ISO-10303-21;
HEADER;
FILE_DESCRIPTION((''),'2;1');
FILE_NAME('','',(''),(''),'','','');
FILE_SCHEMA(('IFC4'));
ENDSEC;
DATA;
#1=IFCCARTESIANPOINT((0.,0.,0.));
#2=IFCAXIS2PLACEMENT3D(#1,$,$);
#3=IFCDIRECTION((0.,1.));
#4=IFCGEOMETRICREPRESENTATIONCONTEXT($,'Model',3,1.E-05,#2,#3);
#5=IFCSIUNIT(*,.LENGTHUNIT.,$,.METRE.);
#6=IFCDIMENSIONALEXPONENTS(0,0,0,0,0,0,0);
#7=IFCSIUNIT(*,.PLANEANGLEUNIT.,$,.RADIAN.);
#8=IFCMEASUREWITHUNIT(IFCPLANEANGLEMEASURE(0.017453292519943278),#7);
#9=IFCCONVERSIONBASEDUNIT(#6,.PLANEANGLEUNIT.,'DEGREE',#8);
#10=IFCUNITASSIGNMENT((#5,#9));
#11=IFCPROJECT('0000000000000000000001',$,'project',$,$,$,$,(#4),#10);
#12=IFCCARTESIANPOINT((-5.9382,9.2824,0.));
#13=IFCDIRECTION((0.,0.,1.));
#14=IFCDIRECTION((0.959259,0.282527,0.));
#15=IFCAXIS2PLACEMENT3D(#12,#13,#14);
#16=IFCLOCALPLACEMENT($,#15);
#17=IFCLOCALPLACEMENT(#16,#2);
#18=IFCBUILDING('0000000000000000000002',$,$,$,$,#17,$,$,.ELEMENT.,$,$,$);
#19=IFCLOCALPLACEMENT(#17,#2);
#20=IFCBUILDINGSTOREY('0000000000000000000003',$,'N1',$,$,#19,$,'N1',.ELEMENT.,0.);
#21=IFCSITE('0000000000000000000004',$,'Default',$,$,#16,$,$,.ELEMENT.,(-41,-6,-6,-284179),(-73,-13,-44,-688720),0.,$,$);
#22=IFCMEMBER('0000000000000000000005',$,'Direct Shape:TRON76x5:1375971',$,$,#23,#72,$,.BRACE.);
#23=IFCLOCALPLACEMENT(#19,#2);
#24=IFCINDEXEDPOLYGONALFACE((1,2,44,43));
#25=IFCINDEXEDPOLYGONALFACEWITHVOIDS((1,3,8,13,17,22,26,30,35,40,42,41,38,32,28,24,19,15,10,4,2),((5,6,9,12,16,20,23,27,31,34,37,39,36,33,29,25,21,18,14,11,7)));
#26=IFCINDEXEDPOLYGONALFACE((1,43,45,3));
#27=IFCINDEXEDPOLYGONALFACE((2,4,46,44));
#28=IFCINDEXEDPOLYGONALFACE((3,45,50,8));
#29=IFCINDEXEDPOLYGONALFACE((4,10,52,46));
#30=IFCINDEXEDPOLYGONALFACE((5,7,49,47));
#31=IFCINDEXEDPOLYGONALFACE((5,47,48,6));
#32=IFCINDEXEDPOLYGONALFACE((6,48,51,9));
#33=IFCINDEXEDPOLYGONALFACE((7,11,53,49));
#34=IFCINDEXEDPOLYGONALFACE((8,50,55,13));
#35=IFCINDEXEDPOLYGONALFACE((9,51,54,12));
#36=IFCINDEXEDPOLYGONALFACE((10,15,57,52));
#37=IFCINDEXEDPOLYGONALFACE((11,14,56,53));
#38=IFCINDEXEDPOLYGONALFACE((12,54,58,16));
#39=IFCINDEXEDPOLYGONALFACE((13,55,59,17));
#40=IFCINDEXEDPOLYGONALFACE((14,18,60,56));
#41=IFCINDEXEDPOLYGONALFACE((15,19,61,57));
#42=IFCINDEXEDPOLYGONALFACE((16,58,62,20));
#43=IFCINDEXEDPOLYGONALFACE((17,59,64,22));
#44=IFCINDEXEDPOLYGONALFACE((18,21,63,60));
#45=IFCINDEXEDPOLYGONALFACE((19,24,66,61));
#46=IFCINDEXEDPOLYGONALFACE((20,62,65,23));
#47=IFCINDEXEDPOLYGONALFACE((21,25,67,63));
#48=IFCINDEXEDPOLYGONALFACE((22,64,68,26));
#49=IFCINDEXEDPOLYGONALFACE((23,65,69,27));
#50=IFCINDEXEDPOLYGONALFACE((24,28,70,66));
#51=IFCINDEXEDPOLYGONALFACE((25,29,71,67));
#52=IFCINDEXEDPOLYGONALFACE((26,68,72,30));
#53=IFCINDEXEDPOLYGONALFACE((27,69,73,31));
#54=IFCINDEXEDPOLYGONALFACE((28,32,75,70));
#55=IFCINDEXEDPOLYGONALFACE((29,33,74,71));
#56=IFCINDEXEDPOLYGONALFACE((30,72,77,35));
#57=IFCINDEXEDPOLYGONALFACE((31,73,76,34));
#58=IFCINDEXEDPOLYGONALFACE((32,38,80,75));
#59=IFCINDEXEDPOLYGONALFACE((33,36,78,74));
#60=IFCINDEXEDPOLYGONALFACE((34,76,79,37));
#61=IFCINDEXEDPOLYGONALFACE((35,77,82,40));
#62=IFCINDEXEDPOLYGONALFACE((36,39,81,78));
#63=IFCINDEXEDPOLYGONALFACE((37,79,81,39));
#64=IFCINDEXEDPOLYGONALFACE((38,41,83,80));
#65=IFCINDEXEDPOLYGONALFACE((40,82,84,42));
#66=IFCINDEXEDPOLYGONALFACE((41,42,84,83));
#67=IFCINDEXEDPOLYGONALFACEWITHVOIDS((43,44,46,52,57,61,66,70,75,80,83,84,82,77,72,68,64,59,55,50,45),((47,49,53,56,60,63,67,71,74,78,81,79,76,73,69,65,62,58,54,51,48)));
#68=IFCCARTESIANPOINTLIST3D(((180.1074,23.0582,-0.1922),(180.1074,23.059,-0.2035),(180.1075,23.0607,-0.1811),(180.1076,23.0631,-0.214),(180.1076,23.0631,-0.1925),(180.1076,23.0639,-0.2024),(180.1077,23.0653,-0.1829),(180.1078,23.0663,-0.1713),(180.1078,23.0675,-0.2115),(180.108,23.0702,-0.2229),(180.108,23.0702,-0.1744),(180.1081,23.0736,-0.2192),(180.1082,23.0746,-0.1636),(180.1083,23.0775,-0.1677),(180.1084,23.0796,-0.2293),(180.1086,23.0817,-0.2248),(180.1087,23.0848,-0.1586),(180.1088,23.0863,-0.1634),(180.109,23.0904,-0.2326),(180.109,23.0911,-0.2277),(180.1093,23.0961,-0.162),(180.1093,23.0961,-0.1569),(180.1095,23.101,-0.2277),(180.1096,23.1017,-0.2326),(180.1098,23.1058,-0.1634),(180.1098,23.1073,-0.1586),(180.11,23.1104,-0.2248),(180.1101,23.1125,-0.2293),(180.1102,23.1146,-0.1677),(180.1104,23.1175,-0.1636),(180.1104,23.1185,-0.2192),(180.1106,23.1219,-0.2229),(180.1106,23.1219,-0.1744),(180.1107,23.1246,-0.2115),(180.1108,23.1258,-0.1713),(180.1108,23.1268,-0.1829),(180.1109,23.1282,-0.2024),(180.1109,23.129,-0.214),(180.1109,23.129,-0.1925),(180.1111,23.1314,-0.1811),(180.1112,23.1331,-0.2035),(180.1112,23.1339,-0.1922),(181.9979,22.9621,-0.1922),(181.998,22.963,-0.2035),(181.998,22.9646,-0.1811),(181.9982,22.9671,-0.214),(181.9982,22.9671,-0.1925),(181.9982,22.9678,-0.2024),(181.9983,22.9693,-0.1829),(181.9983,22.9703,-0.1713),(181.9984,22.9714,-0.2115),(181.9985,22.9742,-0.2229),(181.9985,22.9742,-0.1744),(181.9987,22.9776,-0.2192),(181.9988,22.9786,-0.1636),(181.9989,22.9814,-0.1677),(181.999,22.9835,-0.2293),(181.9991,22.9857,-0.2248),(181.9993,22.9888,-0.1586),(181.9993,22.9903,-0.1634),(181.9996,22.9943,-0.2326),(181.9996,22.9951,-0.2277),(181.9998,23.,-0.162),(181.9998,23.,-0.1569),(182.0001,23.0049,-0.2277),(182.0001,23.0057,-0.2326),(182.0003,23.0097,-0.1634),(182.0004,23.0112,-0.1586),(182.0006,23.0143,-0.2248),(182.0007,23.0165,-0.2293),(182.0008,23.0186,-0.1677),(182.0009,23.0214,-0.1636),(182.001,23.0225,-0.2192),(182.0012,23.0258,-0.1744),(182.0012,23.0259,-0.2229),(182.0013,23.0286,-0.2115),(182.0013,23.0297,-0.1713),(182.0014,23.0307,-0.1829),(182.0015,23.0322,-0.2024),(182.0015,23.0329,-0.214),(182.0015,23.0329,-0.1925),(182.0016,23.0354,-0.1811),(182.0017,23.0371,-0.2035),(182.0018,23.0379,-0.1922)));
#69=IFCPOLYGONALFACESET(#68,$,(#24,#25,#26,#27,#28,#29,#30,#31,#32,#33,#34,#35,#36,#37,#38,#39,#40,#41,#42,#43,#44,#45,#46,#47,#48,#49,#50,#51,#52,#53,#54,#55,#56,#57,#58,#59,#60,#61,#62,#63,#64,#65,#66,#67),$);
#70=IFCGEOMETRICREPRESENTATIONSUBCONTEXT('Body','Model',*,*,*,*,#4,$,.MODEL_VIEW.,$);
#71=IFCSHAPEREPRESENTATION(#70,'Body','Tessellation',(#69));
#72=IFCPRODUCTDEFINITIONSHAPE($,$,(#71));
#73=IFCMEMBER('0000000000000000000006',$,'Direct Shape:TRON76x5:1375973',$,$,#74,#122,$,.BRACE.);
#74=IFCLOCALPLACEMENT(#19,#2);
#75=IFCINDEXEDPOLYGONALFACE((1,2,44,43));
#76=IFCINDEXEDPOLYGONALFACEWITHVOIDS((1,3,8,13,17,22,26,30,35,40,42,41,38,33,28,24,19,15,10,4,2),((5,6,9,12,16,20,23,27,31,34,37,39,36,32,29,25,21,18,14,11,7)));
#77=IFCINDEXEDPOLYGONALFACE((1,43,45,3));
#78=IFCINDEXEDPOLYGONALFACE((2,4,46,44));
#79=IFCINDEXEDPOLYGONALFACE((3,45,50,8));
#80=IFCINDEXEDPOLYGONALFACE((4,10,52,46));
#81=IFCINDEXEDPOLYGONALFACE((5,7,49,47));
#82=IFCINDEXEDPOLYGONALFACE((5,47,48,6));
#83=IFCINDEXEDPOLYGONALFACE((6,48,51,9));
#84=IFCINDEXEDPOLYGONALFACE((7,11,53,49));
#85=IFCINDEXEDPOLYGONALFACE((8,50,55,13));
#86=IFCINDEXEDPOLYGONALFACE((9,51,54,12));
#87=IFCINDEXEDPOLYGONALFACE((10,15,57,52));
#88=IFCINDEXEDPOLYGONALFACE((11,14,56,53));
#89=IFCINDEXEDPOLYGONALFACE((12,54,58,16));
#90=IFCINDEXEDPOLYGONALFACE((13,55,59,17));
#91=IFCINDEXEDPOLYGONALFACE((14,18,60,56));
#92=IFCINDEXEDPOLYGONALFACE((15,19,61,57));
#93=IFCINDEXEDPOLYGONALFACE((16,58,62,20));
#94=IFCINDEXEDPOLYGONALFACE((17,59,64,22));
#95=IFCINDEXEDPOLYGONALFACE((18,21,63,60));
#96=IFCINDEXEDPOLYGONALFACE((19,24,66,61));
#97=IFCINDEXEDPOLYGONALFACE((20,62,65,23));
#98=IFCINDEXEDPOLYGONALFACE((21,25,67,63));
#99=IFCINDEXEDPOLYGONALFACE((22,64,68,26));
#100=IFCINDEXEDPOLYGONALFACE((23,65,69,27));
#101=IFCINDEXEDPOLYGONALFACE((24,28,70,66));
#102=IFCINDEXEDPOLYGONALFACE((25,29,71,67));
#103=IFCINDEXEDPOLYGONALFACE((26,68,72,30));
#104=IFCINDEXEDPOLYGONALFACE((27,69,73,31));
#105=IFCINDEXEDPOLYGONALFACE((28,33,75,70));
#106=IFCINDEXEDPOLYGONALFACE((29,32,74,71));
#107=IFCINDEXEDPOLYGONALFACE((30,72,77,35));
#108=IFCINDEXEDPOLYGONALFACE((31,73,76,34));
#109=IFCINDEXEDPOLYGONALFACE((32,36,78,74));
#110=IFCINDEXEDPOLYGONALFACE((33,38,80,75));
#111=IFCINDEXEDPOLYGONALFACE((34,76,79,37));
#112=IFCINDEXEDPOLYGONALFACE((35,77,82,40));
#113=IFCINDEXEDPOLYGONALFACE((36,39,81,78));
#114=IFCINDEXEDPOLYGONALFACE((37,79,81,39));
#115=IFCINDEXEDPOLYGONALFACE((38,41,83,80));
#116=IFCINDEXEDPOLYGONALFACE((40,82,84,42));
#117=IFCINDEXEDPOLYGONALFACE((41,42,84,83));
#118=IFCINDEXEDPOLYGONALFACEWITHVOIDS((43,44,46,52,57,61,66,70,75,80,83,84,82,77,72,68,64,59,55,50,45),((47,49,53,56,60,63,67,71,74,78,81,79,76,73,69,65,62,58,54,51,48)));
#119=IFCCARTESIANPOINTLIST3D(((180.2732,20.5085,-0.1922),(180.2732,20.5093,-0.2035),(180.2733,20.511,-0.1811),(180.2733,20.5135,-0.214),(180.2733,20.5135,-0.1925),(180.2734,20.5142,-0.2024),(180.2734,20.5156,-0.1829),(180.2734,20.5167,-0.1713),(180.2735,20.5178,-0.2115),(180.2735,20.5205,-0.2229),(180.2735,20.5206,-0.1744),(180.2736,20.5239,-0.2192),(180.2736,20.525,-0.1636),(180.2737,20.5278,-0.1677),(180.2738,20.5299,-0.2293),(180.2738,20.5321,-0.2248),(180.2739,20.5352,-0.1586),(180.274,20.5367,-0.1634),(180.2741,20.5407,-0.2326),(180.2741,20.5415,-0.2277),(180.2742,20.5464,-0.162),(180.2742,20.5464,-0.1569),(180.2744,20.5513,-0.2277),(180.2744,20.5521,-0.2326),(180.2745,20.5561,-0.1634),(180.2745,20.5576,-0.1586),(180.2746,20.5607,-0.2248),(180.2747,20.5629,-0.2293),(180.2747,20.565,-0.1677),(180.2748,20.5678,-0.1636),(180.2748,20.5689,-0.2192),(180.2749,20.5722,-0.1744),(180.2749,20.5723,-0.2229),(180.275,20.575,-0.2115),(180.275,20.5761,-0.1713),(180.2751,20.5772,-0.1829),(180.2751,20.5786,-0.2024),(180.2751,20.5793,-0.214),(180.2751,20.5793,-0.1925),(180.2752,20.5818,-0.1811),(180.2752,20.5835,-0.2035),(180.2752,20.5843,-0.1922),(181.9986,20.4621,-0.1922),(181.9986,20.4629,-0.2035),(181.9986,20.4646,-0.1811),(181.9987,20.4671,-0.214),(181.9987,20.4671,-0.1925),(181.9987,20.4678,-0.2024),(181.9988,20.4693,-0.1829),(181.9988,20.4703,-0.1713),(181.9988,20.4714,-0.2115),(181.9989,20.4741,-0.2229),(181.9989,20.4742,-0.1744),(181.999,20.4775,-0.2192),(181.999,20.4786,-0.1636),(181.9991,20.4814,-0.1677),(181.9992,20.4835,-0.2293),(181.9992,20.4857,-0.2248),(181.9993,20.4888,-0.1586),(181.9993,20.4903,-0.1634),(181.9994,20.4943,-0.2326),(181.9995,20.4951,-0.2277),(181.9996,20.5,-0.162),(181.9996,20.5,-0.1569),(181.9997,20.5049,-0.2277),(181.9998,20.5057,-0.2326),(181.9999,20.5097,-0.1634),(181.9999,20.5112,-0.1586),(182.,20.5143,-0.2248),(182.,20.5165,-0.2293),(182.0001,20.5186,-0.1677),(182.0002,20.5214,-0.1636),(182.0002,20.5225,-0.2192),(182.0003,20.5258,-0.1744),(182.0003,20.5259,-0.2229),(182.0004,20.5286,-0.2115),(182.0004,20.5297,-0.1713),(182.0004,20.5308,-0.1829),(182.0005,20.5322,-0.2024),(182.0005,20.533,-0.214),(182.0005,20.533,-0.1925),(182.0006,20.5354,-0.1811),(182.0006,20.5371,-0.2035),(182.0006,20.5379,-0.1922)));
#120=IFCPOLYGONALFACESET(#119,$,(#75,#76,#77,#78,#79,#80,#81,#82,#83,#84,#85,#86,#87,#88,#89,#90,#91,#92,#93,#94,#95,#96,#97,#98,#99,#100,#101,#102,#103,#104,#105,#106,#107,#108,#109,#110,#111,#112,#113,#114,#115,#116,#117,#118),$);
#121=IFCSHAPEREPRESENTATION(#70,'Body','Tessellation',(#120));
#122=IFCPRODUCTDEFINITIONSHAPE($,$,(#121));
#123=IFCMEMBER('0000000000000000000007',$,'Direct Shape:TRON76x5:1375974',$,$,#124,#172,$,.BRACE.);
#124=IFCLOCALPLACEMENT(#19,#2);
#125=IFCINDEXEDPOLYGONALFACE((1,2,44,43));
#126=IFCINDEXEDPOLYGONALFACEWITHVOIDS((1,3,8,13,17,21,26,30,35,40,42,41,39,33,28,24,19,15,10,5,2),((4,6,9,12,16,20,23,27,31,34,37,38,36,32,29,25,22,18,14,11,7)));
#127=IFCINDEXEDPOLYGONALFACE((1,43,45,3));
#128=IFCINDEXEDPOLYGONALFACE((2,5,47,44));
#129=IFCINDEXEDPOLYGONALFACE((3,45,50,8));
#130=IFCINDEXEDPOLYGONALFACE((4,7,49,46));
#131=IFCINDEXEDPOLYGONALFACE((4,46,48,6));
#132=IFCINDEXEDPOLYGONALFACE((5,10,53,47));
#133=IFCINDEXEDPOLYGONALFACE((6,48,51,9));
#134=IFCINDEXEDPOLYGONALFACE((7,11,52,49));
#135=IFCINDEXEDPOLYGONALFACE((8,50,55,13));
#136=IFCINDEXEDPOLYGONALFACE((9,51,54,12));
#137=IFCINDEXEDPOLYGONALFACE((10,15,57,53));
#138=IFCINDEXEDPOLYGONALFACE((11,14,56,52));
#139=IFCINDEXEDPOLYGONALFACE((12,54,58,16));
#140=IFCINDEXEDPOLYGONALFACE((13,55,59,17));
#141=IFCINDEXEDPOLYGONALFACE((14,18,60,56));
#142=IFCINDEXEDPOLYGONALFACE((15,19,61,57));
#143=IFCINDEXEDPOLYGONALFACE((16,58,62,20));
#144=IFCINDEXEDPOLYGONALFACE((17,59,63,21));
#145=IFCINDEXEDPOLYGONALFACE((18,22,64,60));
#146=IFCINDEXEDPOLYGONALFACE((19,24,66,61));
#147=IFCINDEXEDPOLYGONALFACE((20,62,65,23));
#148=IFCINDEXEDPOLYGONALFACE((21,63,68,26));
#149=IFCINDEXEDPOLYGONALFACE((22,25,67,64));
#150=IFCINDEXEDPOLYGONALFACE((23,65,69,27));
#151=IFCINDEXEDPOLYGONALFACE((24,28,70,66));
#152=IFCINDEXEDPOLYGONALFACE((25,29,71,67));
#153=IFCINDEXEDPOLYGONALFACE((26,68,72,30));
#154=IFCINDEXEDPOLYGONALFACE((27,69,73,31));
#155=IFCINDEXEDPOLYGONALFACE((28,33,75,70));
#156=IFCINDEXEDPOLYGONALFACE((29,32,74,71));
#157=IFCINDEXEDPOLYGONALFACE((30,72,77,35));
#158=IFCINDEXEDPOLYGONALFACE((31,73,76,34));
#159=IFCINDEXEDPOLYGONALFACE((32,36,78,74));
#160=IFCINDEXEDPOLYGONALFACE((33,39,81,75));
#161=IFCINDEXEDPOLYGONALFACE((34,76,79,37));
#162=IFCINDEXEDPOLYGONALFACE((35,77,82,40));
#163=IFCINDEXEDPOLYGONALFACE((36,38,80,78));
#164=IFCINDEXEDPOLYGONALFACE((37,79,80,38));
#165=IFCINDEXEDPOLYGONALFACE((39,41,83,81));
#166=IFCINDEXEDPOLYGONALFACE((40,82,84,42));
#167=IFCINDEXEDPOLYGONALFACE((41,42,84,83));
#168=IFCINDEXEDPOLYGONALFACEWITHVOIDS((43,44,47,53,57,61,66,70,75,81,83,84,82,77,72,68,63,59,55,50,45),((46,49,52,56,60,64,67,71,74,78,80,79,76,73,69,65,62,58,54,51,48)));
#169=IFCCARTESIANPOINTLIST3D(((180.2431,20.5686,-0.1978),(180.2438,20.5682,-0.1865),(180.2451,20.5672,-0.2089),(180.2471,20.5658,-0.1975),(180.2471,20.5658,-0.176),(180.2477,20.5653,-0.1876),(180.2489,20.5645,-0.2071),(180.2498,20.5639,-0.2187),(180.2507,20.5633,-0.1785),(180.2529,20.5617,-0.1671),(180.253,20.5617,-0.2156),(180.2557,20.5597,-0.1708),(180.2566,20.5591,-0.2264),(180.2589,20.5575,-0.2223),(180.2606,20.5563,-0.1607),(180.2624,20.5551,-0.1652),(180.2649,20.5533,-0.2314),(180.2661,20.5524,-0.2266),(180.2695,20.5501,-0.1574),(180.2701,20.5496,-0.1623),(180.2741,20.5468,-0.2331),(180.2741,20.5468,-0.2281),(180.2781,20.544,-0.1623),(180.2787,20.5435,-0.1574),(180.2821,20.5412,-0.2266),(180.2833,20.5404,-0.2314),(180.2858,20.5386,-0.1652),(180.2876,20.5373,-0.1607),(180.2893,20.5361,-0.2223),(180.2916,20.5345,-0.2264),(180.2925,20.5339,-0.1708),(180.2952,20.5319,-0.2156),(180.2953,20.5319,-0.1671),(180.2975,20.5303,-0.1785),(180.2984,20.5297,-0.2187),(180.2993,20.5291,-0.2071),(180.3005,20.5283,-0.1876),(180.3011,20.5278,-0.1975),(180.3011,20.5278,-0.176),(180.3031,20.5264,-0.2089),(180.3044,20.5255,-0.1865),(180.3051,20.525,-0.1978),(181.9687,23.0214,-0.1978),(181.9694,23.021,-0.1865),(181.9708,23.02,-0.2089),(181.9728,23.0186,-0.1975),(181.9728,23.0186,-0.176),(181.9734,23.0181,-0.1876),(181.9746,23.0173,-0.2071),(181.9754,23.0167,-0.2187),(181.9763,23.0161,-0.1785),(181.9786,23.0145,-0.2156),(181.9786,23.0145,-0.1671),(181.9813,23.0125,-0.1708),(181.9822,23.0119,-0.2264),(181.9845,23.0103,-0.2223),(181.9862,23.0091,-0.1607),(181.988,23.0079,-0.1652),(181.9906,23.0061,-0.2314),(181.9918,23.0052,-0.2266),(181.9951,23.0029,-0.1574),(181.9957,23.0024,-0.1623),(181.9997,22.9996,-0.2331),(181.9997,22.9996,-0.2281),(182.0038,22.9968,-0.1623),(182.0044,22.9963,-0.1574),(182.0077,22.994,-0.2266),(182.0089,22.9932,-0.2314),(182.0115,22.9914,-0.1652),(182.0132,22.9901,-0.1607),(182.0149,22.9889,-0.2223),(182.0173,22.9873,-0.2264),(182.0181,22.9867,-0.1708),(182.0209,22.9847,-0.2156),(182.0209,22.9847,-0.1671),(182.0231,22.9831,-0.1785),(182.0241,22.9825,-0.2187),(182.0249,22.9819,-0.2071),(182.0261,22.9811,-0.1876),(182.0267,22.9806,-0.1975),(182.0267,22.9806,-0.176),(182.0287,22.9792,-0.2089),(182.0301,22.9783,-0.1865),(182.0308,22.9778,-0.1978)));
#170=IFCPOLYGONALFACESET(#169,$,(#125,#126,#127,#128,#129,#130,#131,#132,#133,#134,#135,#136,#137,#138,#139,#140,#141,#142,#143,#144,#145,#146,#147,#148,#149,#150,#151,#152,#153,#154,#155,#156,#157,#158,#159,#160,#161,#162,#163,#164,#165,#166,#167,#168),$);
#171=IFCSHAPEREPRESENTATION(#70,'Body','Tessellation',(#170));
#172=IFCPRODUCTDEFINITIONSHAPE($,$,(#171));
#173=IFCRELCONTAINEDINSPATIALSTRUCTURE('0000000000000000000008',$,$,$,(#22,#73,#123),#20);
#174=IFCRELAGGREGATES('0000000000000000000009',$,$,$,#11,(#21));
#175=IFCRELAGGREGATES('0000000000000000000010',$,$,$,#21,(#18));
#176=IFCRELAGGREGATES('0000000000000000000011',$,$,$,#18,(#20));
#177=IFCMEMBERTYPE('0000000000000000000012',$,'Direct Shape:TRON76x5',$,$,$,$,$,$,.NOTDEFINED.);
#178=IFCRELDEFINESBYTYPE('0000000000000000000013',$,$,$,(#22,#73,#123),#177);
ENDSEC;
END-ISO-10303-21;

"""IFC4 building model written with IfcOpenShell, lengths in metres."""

from ifc_helpers import new_model, entity, si_unit, converted_unit, direction, frame, frame_2d, origin, place, context, subcontext, project, spatial, hollow_circle, extrude, type_object, element, save


model = new_model("IFC4")

# Units and contexts
model_context = context("Model", 3, precision=1e-05, world=origin(), true_north=direction((0.0, 1.0)))
body_context = subcontext(model_context, "Body", "Model", "MODEL_VIEW")
ifc_project = project(units=[si_unit("LENGTHUNIT", "METRE"), converted_unit("PLANEANGLEUNIT", "DEGREE", entity("IfcPlaneAngleMeasure", 0.017453292519943278), si_unit("PLANEANGLEUNIT", "RADIAN"), dimensions=[0, 0, 0, 0, 0, 0, 0])], contexts=[model_context])

# Site, building, storey
site_placement = place(None, frame((-5.9382, 9.2824, 0.0), z_axis=(0.0, 0.0, 1.0), x_axis=(0.959259, 0.282527, 0.0)))
site = spatial("IfcSite", under=ifc_project, at=site_placement, Name="Default", CompositionType="ELEMENT", RefLatitude=(-41, -6, -6, -284179), RefLongitude=(-73, -13, -44, -688720), RefElevation=0.0)
building_placement = place(site_placement, origin())
building = spatial("IfcBuilding", under=site, at=building_placement, CompositionType="ELEMENT")
storey_placement = place(building_placement, origin())
storey = spatial("IfcBuildingStorey", under=building, at=storey_placement, Name="N1", LongName="N1", CompositionType="ELEMENT", Elevation=0.0)

# Members
member_type_1 = type_object("IfcMemberType", Name="Direct Shape:TRON76x5", PredefinedType="NOTDEFINED")
member_1_placement = place(storey_placement, origin())
element("IfcMember", 1, at=member_1_placement, inside=storey, type_object=member_type_1, Name="Direct Shape:TRON76x5:1375971", PredefinedType="BRACE", context=body_context, shape_type="SweptSolid", body=[
    extrude(hollow_circle(Radius=0.0381, WallThickness=0.005, at=frame_2d((0.0, 0.0), x_axis=(1.0, 0.0))), frame((181.9998, 23.0, -0.195), z_axis=(-0.998712, 0.050736, 0.0), x_axis=(0.0, 0.0, 1.0)), (0.0, 0.0, 1.0), 1.893),
])
member_2_placement = place(storey_placement, origin())
element("IfcMember", 2, at=member_2_placement, inside=storey, type_object=member_type_1, Name="Direct Shape:TRON76x5:1375973", PredefinedType="BRACE", context=body_context, shape_type="SweptSolid", body=[
    extrude(hollow_circle(Radius=0.0381, WallThickness=0.005, at=frame_2d((0.0, 0.0), x_axis=(1.0, 0.0))), frame((181.9996, 20.5, -0.195), z_axis=(-0.999639, 0.026877, 0.0), x_axis=(0.0, 0.0, 1.0)), (0.0, 0.0, 1.0), 1.726),
])
member_3_placement = place(storey_placement, origin())
element("IfcMember", 3, at=member_3_placement, inside=storey, type_object=member_type_1, Name="Direct Shape:TRON76x5:1375974", PredefinedType="BRACE", context=body_context, shape_type="SweptSolid", body=[
    extrude(hollow_circle(Radius=0.0381, WallThickness=0.005, at=frame_2d((0.0, 0.0), x_axis=(1.0, 0.0))), frame((180.2741, 20.5468, -0.195), z_axis=(0.575399, 0.817873, 0.0), x_axis=(0.0, 0.0, -1.0)), (0.0, 0.0, 1.0), 2.999),
])

save(model, "model.ifc")
